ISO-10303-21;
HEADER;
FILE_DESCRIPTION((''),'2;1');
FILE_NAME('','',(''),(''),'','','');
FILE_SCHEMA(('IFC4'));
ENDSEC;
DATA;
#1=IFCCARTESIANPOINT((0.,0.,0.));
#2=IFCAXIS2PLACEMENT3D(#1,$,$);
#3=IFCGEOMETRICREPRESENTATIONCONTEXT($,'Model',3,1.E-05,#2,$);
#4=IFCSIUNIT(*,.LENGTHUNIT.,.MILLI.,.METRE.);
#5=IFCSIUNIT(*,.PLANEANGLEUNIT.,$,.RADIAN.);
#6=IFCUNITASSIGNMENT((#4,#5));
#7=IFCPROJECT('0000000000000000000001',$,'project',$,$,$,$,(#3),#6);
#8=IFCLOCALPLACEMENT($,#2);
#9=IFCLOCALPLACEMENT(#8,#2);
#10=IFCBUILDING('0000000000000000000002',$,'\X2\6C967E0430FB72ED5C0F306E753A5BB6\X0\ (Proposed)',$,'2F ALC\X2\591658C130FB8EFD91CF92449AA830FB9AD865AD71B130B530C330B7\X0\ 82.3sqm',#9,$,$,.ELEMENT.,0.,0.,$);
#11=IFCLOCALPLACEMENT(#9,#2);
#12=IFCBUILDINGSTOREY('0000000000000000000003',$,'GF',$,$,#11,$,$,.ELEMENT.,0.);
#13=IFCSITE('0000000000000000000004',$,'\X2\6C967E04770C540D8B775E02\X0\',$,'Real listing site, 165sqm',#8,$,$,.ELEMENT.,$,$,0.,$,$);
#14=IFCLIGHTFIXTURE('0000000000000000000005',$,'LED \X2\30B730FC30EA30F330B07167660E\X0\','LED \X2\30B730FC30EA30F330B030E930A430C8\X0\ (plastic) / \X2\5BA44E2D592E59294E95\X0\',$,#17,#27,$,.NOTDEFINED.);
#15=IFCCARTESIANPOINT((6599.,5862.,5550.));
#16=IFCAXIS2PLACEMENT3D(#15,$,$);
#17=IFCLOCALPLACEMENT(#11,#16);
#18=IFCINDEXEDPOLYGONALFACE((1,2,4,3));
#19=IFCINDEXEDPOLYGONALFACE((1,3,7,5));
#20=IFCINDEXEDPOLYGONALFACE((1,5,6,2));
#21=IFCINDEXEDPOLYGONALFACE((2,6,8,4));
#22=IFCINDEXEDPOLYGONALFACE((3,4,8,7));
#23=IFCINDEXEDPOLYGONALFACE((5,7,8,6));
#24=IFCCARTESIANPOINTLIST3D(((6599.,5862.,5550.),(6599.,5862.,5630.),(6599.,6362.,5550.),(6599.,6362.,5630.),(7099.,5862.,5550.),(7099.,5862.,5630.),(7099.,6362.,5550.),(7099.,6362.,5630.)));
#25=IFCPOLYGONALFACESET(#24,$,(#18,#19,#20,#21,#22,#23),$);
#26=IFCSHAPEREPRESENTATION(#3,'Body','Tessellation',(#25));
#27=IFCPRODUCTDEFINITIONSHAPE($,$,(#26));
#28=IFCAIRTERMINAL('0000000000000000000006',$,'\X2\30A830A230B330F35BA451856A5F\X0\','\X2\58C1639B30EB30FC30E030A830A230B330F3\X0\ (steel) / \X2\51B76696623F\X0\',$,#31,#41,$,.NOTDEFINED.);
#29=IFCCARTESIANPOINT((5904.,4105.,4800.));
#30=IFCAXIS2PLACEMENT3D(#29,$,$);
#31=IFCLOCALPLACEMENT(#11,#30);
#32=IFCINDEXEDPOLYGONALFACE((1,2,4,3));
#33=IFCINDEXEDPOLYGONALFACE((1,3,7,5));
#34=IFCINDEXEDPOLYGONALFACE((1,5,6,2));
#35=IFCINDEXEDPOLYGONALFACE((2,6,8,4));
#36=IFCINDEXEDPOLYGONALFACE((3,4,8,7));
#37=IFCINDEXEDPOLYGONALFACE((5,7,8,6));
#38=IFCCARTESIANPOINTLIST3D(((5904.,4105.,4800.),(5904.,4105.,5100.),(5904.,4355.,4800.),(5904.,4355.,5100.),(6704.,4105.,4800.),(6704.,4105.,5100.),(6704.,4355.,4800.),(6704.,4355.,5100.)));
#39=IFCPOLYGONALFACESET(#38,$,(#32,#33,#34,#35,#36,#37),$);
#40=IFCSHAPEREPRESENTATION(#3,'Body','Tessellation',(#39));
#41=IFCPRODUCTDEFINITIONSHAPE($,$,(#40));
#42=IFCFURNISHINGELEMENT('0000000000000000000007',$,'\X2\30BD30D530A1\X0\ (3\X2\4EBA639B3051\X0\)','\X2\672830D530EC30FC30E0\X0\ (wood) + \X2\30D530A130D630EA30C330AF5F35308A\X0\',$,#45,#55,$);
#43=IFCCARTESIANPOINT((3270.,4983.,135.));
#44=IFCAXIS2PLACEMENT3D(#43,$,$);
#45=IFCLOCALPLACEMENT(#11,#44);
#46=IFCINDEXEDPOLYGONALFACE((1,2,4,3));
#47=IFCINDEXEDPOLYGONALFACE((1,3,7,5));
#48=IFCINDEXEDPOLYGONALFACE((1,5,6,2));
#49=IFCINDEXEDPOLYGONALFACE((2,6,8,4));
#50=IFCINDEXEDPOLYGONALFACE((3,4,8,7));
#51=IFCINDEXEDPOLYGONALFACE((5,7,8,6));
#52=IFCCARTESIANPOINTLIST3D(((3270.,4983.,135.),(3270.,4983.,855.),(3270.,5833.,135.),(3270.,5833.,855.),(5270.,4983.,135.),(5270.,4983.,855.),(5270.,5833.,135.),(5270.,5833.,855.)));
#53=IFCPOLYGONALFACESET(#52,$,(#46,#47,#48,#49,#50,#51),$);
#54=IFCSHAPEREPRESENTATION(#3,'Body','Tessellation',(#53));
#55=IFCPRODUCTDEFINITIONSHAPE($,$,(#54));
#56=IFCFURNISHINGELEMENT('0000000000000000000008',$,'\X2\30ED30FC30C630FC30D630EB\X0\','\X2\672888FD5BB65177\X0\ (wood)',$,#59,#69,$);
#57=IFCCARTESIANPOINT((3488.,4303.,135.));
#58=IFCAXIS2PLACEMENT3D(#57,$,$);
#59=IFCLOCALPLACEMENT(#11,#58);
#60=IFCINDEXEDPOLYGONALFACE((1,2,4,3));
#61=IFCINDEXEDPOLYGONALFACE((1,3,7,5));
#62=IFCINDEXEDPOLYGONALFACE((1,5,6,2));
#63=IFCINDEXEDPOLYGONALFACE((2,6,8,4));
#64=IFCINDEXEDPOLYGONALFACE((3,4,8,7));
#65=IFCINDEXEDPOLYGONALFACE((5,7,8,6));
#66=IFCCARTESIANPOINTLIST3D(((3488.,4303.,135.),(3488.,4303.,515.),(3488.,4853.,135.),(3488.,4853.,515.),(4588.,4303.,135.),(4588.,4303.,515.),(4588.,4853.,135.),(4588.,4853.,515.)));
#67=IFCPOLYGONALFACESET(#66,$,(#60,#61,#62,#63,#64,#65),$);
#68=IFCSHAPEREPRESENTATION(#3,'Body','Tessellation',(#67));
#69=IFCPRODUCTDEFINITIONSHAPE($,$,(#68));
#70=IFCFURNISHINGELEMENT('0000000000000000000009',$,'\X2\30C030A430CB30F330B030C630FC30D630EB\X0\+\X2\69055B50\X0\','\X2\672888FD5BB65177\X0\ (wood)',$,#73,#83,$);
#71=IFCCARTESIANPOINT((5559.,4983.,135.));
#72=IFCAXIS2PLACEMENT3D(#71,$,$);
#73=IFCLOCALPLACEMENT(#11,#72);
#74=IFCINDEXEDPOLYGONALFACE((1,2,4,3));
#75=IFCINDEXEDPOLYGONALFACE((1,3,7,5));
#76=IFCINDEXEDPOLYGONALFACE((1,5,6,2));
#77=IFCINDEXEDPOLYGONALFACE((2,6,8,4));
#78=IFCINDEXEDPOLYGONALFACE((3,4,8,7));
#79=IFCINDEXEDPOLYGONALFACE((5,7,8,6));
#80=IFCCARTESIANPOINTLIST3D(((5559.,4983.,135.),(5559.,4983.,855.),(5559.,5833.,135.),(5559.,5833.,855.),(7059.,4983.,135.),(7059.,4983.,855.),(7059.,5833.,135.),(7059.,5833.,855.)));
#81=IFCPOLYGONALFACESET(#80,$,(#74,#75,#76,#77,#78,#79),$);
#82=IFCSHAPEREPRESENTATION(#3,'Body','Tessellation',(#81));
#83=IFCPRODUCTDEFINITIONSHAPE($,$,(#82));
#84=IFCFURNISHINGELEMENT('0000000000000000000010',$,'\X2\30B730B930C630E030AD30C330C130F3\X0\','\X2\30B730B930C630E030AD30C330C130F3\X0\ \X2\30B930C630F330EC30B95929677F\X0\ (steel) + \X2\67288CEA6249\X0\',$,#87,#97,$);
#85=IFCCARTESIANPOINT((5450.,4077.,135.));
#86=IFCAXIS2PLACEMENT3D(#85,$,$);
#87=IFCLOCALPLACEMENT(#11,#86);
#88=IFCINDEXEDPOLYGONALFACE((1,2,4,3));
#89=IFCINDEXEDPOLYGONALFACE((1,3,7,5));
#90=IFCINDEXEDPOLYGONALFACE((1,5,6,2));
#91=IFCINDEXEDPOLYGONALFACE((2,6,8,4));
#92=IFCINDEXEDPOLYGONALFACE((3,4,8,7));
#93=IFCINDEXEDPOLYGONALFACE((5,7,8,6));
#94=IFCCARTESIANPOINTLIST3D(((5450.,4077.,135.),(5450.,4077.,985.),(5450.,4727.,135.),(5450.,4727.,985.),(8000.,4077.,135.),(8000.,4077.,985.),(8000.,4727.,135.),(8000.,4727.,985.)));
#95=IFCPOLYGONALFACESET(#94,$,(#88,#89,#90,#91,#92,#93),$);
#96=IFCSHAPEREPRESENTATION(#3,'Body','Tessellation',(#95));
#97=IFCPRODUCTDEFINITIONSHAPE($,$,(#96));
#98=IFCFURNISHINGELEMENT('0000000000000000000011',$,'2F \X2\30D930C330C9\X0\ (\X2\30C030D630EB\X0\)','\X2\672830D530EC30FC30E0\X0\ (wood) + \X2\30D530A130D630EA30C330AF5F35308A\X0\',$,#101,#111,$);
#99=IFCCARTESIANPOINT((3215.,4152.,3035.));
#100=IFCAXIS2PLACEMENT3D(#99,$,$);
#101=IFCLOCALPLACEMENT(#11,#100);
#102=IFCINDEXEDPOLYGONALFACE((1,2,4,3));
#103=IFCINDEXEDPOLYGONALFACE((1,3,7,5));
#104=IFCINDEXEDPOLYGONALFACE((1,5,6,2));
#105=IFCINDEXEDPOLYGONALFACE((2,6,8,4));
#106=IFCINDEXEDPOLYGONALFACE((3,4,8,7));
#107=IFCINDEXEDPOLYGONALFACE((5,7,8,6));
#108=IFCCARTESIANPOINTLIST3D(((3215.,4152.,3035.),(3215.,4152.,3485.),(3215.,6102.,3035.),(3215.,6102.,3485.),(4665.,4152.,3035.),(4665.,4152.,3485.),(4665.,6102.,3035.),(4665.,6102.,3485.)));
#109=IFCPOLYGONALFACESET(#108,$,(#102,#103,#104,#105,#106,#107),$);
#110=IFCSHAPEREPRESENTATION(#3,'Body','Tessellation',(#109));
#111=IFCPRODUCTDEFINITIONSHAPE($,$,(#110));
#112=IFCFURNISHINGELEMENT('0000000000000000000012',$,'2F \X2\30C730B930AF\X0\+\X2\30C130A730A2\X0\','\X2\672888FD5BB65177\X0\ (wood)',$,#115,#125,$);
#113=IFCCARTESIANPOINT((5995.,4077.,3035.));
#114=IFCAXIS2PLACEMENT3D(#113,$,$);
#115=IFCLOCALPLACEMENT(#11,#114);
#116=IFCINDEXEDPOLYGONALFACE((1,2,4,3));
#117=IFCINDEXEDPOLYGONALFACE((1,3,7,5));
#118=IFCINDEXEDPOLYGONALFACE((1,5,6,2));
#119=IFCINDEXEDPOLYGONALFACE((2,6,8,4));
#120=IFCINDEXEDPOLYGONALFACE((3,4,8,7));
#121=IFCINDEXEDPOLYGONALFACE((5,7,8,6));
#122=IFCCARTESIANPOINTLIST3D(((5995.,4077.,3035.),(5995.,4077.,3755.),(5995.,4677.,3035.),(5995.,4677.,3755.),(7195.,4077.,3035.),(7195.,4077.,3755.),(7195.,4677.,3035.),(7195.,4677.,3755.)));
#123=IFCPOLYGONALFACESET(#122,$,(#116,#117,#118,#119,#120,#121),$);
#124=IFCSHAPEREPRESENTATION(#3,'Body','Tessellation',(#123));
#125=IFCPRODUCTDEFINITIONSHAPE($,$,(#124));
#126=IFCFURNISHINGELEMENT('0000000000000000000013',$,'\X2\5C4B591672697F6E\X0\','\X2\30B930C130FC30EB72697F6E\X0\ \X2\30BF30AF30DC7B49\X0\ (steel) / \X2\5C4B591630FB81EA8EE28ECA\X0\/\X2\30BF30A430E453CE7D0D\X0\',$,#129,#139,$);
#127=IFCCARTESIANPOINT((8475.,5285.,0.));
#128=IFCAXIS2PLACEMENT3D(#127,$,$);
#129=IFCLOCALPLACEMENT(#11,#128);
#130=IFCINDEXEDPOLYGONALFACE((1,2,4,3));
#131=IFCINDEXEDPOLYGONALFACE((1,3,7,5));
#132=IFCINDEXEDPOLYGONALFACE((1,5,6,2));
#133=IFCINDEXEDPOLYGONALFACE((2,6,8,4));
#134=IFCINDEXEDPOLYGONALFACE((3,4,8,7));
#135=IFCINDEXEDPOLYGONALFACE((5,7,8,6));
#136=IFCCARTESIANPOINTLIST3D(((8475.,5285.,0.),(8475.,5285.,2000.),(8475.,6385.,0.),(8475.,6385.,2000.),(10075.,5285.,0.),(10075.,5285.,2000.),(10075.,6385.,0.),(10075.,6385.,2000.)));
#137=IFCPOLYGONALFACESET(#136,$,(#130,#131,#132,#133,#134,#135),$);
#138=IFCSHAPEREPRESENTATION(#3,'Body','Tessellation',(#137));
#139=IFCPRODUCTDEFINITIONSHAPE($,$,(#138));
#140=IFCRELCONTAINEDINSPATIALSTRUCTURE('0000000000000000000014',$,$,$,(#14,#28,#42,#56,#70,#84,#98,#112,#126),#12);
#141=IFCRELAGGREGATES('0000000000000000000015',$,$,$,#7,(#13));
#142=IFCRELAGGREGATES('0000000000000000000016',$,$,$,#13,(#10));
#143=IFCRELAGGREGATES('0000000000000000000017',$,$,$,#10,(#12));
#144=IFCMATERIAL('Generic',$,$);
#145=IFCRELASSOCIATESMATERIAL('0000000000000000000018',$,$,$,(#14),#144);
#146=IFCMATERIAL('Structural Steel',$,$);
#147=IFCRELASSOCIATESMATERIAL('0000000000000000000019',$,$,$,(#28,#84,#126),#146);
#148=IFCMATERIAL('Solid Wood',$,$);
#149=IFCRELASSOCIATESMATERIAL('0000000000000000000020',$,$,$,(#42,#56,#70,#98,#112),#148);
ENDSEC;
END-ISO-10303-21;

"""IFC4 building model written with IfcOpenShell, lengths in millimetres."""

from ifc_helpers import new_model, si_unit, frame, frame_2d, origin, place, context, project, spatial, rectangle, extrude, material, element, save


model = new_model("IFC4")

# Units and contexts
model_context = context("Model", 3, precision=1e-05, world=origin())
ifc_project = project(units=[si_unit("LENGTHUNIT", "METRE", prefix="MILLI"), si_unit("PLANEANGLEUNIT", "RADIAN")], contexts=[model_context])

# Site, building, storey
site_placement = place(None, origin())
site = spatial("IfcSite", under=ifc_project, at=site_placement, Name="沖縄県名護市", ObjectType="Real listing site, 165sqm", CompositionType="ELEMENT", RefElevation=0.0)
building_placement = place(site_placement, origin())
building = spatial("IfcBuilding", under=site, at=building_placement, Name="沖縄・狭小の町家 (Proposed)", ObjectType="2F ALC外壁・軽量鉄骨・高断熱サッシ 82.3sqm", CompositionType="ELEMENT", ElevationOfRefHeight=0.0, ElevationOfTerrain=0.0)
storey_placement = place(building_placement, origin())
storey = spatial("IfcBuildingStorey", under=building, at=storey_placement, Name="GF", CompositionType="ELEMENT", Elevation=0.0)

# Shared definitions
ifc_material_1 = material(Name="Solid Wood")

# Shared definitions
ifc_material_2 = material(Name="Generic")

# Shared definitions
ifc_material_3 = material(Name="Structural Steel")

# Light fixture
light_fixture_placement = place(storey_placement, frame((6599.0, 5862.0, 5550.0)))
element("IfcLightFixture", 1, at=light_fixture_placement, inside=storey, material=ifc_material_2, Name="LED シーリング照明", Description="LED シーリングライト (plastic) / 室中央天井", PredefinedType="NOTDEFINED", context=model_context, shape_type="SweptSolid", body=[
    extrude(rectangle(XDim=500.0, YDim=500.0, at=frame_2d((250.0, 250.0))), frame((6599.0, 5862.0, 5550.0)), (0.0, 0.0, 1.0), 80.0),
])

# Air terminal
air_terminal_1_placement = place(storey_placement, frame((5904.0, 4105.0, 4800.0)))
element("IfcAirTerminal", 2, at=air_terminal_1_placement, inside=storey, material=ifc_material_3, Name="エアコン室内機", Description="壁掛ルームエアコン (steel) / 冷暖房", PredefinedType="NOTDEFINED", context=model_context, shape_type="SweptSolid", body=[
    extrude(rectangle(XDim=800.0, YDim=250.0, at=frame_2d((400.0, 125.0))), frame((5904.0, 4105.0, 4800.0)), (0.0, 0.0, 1.0), 300.0),
])

# Furnishing elements
furnishing_1_placement = place(storey_placement, frame((3270.0, 4983.0, 135.0)))
element("IfcFurnishingElement", 3, at=furnishing_1_placement, inside=storey, material=ifc_material_1, Name="ソファ (3人掛け)", Description="木フレーム (wood) + ファブリック張り", context=model_context, shape_type="SweptSolid", body=[
    extrude(rectangle(XDim=2000.0, YDim=850.0, at=frame_2d((1000.0, 425.0))), frame((3270.0, 4983.0, 135.0)), (0.0, 0.0, 1.0), 720.0),
])
furnishing_2_placement = place(storey_placement, frame((3488.0, 4303.0, 135.0)))
element("IfcFurnishingElement", 4, at=furnishing_2_placement, inside=storey, material=ifc_material_1, Name="ローテーブル", Description="木製家具 (wood)", context=model_context, shape_type="SweptSolid", body=[
    extrude(rectangle(XDim=1100.0, YDim=550.0, at=frame_2d((550.0, 275.0))), frame((3488.0, 4303.0, 135.0)), (0.0, 0.0, 1.0), 380.0),
])
furnishing_3_placement = place(storey_placement, frame((5559.0, 4983.0, 135.0)))
element("IfcFurnishingElement", 5, at=furnishing_3_placement, inside=storey, material=ifc_material_1, Name="ダイニングテーブル+椅子", Description="木製家具 (wood)", context=model_context, shape_type="SweptSolid", body=[
    extrude(rectangle(XDim=1500.0, YDim=850.0, at=frame_2d((750.0, 425.0))), frame((5559.0, 4983.0, 135.0)), (0.0, 0.0, 1.0), 720.0),
])
furnishing_4_placement = place(storey_placement, frame((5450.0, 4077.0, 135.0)))
element("IfcFurnishingElement", 6, at=furnishing_4_placement, inside=storey, material=ifc_material_3, Name="システムキッチン", Description="システムキッチン ステンレス天板 (steel) + 木質扉", context=model_context, shape_type="SweptSolid", body=[
    extrude(rectangle(XDim=2550.0, YDim=650.0, at=frame_2d((1275.0, 325.0))), frame((5450.0, 4077.0, 135.0)), (0.0, 0.0, 1.0), 850.0),
])
furnishing_5_placement = place(storey_placement, frame((3215.0, 4152.0, 3035.0)))
element("IfcFurnishingElement", 7, at=furnishing_5_placement, inside=storey, material=ifc_material_1, Name="2F ベッド (ダブル)", Description="木フレーム (wood) + ファブリック張り", context=model_context, shape_type="SweptSolid", body=[
    extrude(rectangle(XDim=1450.0, YDim=1950.0, at=frame_2d((725.0, 975.0))), frame((3215.0, 4152.0, 3035.0)), (0.0, 0.0, 1.0), 450.0),
])
furnishing_6_placement = place(storey_placement, frame((5995.0, 4077.0, 3035.0)))
element("IfcFurnishingElement", 8, at=furnishing_6_placement, inside=storey, material=ifc_material_1, Name="2F デスク+チェア", Description="木製家具 (wood)", context=model_context, shape_type="SweptSolid", body=[
    extrude(rectangle(XDim=1200.0, YDim=600.0, at=frame_2d((600.0, 300.0))), frame((5995.0, 4077.0, 3035.0)), (0.0, 0.0, 1.0), 720.0),
])
furnishing_7_placement = place(storey_placement, frame((8475.0, 5285.0, 0.0)))
element("IfcFurnishingElement", 9, at=furnishing_7_placement, inside=storey, material=ifc_material_3, Name="屋外物置", Description="スチール物置 タクボ等 (steel) / 屋外・自転車/タイヤ収納", context=model_context, shape_type="SweptSolid", body=[
    extrude(rectangle(XDim=1600.0, YDim=1100.0, at=frame_2d((800.0, 550.0))), frame((8475.0, 5285.0, 0.0)), (0.0, 0.0, 1.0), 2000.0),
])

save(model, "model.ifc")
